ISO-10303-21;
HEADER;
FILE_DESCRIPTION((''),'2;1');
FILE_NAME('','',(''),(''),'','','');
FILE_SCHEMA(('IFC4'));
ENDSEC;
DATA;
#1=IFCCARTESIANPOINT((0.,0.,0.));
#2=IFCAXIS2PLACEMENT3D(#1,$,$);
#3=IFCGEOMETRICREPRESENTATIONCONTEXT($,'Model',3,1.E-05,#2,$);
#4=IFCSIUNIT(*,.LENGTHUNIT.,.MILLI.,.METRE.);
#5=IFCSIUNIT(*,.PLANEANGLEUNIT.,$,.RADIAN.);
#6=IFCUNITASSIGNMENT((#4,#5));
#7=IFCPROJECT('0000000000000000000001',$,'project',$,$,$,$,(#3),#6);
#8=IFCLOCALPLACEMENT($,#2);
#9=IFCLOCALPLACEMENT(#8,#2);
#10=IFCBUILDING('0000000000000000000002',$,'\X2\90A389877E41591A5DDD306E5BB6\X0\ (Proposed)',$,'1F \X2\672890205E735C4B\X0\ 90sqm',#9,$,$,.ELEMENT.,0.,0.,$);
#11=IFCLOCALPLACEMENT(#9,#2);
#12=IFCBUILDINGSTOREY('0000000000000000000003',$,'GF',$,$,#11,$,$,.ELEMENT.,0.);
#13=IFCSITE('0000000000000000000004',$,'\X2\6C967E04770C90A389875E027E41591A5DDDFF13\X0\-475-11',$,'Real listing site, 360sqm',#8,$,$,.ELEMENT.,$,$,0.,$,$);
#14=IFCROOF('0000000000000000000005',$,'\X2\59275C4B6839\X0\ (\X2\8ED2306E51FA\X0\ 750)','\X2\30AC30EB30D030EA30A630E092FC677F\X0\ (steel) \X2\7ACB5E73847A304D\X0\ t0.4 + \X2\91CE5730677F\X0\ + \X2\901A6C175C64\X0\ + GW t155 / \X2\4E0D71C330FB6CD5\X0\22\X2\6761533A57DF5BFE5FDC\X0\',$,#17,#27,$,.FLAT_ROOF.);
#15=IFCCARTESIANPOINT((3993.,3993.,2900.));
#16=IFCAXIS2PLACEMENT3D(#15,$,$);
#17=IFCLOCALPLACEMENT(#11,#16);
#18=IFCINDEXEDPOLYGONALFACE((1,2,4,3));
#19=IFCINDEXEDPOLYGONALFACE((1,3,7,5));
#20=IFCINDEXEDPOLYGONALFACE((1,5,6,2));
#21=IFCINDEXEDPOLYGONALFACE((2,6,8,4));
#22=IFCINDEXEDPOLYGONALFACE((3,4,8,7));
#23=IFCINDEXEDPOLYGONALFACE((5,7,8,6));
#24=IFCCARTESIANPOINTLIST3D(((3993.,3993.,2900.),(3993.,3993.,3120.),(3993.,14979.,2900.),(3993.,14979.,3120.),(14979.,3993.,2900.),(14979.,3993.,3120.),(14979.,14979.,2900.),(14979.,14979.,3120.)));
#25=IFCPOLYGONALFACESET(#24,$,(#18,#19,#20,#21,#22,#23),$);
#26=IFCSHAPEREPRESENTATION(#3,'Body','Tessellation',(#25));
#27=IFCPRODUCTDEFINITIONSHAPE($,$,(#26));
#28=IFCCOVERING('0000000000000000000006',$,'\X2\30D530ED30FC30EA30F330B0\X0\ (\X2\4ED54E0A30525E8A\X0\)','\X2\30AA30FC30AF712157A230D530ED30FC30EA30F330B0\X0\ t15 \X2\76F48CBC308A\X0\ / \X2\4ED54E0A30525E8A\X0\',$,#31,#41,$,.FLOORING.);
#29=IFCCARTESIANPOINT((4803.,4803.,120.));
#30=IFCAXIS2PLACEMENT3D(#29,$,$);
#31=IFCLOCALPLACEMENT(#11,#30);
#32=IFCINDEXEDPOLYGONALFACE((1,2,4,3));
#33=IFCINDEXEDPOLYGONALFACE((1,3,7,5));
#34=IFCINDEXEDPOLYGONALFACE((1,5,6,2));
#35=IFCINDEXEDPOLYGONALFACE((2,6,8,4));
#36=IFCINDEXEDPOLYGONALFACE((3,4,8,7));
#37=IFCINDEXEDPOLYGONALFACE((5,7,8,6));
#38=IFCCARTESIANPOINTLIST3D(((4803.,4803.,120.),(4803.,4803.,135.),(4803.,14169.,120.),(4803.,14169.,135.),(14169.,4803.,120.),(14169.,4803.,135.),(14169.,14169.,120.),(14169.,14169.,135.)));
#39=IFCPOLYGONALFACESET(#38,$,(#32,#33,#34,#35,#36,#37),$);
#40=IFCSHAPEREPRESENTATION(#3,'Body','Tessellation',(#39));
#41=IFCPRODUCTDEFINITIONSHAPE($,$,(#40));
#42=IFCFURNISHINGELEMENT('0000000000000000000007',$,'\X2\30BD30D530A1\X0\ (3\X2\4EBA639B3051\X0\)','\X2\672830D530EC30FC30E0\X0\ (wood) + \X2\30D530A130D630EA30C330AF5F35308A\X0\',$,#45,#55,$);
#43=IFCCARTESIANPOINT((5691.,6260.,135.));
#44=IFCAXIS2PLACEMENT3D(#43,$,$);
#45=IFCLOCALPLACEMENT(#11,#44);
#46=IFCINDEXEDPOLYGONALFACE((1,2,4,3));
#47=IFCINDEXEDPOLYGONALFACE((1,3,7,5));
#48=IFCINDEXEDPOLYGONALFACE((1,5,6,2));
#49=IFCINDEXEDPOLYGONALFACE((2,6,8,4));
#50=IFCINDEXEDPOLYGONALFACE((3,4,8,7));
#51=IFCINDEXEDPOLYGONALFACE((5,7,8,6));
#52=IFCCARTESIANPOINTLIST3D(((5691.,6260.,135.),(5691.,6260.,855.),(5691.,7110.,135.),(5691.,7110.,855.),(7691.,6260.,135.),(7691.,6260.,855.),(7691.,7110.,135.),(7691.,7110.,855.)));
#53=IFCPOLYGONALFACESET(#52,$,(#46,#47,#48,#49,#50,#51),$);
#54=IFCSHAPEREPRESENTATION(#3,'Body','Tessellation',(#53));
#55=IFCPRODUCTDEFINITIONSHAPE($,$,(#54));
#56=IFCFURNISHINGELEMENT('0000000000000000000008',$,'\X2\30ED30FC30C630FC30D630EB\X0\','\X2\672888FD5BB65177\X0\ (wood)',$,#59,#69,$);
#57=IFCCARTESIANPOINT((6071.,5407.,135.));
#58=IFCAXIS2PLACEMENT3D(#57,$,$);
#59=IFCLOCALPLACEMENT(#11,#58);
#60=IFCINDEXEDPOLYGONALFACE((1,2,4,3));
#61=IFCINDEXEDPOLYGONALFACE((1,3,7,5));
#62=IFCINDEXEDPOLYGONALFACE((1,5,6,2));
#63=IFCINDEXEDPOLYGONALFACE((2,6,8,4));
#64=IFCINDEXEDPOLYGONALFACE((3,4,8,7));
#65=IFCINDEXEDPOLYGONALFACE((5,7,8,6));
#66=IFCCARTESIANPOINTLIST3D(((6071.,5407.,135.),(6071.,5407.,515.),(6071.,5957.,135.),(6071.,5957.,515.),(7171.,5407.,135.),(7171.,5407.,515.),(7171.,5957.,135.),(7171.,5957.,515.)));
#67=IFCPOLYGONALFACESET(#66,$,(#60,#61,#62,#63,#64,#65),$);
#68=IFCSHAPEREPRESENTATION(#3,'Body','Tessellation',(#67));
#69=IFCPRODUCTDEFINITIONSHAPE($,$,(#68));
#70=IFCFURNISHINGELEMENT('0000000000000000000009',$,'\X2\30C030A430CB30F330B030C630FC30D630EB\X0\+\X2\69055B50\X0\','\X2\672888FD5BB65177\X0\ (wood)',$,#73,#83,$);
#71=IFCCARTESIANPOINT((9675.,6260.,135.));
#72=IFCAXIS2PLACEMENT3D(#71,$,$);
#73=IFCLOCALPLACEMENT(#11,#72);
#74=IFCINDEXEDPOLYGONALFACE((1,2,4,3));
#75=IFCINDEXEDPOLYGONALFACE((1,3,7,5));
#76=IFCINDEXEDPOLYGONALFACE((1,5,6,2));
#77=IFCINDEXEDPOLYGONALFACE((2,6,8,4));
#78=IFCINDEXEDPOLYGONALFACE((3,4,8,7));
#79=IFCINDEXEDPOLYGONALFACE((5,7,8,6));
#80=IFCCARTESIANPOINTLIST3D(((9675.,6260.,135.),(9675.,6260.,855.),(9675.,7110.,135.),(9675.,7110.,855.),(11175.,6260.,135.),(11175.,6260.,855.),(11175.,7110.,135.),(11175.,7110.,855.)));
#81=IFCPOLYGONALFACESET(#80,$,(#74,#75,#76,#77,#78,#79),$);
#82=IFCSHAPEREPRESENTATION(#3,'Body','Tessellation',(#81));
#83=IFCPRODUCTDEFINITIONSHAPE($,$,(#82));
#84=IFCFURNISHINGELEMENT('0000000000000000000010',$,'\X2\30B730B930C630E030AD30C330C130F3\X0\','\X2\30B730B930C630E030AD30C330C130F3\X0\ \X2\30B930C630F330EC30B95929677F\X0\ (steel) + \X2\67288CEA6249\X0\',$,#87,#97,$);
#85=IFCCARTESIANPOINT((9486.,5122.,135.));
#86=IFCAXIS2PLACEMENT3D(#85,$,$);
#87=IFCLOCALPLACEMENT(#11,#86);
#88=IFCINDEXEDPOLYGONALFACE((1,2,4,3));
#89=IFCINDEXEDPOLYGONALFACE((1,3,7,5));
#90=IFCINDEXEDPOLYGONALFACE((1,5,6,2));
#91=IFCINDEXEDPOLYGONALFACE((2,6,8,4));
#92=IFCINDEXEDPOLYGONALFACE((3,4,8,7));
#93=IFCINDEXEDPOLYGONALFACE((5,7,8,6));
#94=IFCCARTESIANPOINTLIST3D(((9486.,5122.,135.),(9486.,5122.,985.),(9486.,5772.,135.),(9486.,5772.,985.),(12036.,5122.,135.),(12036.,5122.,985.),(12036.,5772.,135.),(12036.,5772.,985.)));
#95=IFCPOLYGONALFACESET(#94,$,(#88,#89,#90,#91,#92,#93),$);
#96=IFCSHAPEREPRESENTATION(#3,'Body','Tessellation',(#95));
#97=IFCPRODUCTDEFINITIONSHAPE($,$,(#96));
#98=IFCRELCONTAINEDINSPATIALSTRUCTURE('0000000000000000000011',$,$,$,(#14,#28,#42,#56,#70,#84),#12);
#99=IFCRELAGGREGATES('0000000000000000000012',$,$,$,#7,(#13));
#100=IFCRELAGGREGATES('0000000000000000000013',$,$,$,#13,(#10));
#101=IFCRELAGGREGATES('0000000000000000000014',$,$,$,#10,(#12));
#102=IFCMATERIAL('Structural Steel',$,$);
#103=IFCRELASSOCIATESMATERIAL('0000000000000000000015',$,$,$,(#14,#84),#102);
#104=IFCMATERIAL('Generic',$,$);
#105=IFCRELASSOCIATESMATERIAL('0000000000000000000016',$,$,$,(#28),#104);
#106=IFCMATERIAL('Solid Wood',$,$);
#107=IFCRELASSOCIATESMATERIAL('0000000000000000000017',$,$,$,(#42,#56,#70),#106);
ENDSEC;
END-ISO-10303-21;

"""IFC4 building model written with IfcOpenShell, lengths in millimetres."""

from ifc_helpers import new_model, si_unit, frame, frame_2d, origin, place, context, project, spatial, rectangle, extrude, material, element, save


model = new_model("IFC4")

# Units and contexts
model_context = context("Model", 3, precision=1e-05, world=origin())
ifc_project = project(units=[si_unit("LENGTHUNIT", "METRE", prefix="MILLI"), si_unit("PLANEANGLEUNIT", "RADIAN")], contexts=[model_context])

# Site, building, storey
site_placement = place(None, origin())
site = spatial("IfcSite", under=ifc_project, at=site_placement, Name="沖縄県那覇市繁多川３-475-11", ObjectType="Real listing site, 360sqm", CompositionType="ELEMENT", RefElevation=0.0)
building_placement = place(site_placement, origin())
building = spatial("IfcBuilding", under=site, at=building_placement, Name="那覇繁多川の家 (Proposed)", ObjectType="1F 木造平屋 90sqm", CompositionType="ELEMENT", ElevationOfRefHeight=0.0, ElevationOfTerrain=0.0)
storey_placement = place(building_placement, origin())
storey = spatial("IfcBuildingStorey", under=building, at=storey_placement, Name="GF", CompositionType="ELEMENT", Elevation=0.0)

# Shared definitions
ifc_material_1 = material(Name="Solid Wood")

# Roof
ifc_material_2 = material(Name="Structural Steel")
roof_placement = place(storey_placement, frame((3993.0, 3993.0, 2900.0)))
element("IfcRoof", 1, at=roof_placement, inside=storey, material=ifc_material_2, Name="大屋根 (軒の出 750)", Description="ガルバリウム鋼板 (steel) 立平葺き t0.4 + 野地板 + 通気層 + GW t155 / 不燃・法22条区域対応", PredefinedType="FLAT_ROOF", context=model_context, shape_type="SweptSolid", body=[
    extrude(rectangle(XDim=10986.0, YDim=10986.0, at=frame_2d((5493.0, 5493.0))), frame((3993.0, 3993.0, 2900.0)), (0.0, 0.0, 1.0), 220.0),
])

# Covering
ifc_material_3 = material(Name="Generic")
covering_placement = place(storey_placement, frame((4803.0, 4803.0, 120.0)))
element("IfcCovering", 2, at=covering_placement, inside=storey, material=ifc_material_3, Name="フローリング (仕上げ床)", Description="オーク無垢フローリング t15 直貼り / 仕上げ床", PredefinedType="FLOORING", context=model_context, shape_type="SweptSolid", body=[
    extrude(rectangle(XDim=9366.0, YDim=9366.0, at=frame_2d((4683.0, 4683.0))), frame((4803.0, 4803.0, 120.0)), (0.0, 0.0, 1.0), 15.0),
])

# Furnishing elements
furnishing_1_placement = place(storey_placement, frame((5691.0, 6260.0, 135.0)))
element("IfcFurnishingElement", 3, at=furnishing_1_placement, inside=storey, material=ifc_material_1, Name="ソファ (3人掛け)", Description="木フレーム (wood) + ファブリック張り", context=model_context, shape_type="SweptSolid", body=[
    extrude(rectangle(XDim=2000.0, YDim=850.0, at=frame_2d((1000.0, 425.0))), frame((5691.0, 6260.0, 135.0)), (0.0, 0.0, 1.0), 720.0),
])
furnishing_2_placement = place(storey_placement, frame((6071.0, 5407.0, 135.0)))
element("IfcFurnishingElement", 4, at=furnishing_2_placement, inside=storey, material=ifc_material_1, Name="ローテーブル", Description="木製家具 (wood)", context=model_context, shape_type="SweptSolid", body=[
    extrude(rectangle(XDim=1100.0, YDim=550.0, at=frame_2d((550.0, 275.0))), frame((6071.0, 5407.0, 135.0)), (0.0, 0.0, 1.0), 380.0),
])
furnishing_3_placement = place(storey_placement, frame((9675.0, 6260.0, 135.0)))
element("IfcFurnishingElement", 5, at=furnishing_3_placement, inside=storey, material=ifc_material_1, Name="ダイニングテーブル+椅子", Description="木製家具 (wood)", context=model_context, shape_type="SweptSolid", body=[
    extrude(rectangle(XDim=1500.0, YDim=850.0, at=frame_2d((750.0, 425.0))), frame((9675.0, 6260.0, 135.0)), (0.0, 0.0, 1.0), 720.0),
])
furnishing_4_placement = place(storey_placement, frame((9486.0, 5122.0, 135.0)))
element("IfcFurnishingElement", 6, at=furnishing_4_placement, inside=storey, material=ifc_material_2, Name="システムキッチン", Description="システムキッチン ステンレス天板 (steel) + 木質扉", context=model_context, shape_type="SweptSolid", body=[
    extrude(rectangle(XDim=2550.0, YDim=650.0, at=frame_2d((1275.0, 325.0))), frame((9486.0, 5122.0, 135.0)), (0.0, 0.0, 1.0), 850.0),
])

save(model, "model.ifc")
